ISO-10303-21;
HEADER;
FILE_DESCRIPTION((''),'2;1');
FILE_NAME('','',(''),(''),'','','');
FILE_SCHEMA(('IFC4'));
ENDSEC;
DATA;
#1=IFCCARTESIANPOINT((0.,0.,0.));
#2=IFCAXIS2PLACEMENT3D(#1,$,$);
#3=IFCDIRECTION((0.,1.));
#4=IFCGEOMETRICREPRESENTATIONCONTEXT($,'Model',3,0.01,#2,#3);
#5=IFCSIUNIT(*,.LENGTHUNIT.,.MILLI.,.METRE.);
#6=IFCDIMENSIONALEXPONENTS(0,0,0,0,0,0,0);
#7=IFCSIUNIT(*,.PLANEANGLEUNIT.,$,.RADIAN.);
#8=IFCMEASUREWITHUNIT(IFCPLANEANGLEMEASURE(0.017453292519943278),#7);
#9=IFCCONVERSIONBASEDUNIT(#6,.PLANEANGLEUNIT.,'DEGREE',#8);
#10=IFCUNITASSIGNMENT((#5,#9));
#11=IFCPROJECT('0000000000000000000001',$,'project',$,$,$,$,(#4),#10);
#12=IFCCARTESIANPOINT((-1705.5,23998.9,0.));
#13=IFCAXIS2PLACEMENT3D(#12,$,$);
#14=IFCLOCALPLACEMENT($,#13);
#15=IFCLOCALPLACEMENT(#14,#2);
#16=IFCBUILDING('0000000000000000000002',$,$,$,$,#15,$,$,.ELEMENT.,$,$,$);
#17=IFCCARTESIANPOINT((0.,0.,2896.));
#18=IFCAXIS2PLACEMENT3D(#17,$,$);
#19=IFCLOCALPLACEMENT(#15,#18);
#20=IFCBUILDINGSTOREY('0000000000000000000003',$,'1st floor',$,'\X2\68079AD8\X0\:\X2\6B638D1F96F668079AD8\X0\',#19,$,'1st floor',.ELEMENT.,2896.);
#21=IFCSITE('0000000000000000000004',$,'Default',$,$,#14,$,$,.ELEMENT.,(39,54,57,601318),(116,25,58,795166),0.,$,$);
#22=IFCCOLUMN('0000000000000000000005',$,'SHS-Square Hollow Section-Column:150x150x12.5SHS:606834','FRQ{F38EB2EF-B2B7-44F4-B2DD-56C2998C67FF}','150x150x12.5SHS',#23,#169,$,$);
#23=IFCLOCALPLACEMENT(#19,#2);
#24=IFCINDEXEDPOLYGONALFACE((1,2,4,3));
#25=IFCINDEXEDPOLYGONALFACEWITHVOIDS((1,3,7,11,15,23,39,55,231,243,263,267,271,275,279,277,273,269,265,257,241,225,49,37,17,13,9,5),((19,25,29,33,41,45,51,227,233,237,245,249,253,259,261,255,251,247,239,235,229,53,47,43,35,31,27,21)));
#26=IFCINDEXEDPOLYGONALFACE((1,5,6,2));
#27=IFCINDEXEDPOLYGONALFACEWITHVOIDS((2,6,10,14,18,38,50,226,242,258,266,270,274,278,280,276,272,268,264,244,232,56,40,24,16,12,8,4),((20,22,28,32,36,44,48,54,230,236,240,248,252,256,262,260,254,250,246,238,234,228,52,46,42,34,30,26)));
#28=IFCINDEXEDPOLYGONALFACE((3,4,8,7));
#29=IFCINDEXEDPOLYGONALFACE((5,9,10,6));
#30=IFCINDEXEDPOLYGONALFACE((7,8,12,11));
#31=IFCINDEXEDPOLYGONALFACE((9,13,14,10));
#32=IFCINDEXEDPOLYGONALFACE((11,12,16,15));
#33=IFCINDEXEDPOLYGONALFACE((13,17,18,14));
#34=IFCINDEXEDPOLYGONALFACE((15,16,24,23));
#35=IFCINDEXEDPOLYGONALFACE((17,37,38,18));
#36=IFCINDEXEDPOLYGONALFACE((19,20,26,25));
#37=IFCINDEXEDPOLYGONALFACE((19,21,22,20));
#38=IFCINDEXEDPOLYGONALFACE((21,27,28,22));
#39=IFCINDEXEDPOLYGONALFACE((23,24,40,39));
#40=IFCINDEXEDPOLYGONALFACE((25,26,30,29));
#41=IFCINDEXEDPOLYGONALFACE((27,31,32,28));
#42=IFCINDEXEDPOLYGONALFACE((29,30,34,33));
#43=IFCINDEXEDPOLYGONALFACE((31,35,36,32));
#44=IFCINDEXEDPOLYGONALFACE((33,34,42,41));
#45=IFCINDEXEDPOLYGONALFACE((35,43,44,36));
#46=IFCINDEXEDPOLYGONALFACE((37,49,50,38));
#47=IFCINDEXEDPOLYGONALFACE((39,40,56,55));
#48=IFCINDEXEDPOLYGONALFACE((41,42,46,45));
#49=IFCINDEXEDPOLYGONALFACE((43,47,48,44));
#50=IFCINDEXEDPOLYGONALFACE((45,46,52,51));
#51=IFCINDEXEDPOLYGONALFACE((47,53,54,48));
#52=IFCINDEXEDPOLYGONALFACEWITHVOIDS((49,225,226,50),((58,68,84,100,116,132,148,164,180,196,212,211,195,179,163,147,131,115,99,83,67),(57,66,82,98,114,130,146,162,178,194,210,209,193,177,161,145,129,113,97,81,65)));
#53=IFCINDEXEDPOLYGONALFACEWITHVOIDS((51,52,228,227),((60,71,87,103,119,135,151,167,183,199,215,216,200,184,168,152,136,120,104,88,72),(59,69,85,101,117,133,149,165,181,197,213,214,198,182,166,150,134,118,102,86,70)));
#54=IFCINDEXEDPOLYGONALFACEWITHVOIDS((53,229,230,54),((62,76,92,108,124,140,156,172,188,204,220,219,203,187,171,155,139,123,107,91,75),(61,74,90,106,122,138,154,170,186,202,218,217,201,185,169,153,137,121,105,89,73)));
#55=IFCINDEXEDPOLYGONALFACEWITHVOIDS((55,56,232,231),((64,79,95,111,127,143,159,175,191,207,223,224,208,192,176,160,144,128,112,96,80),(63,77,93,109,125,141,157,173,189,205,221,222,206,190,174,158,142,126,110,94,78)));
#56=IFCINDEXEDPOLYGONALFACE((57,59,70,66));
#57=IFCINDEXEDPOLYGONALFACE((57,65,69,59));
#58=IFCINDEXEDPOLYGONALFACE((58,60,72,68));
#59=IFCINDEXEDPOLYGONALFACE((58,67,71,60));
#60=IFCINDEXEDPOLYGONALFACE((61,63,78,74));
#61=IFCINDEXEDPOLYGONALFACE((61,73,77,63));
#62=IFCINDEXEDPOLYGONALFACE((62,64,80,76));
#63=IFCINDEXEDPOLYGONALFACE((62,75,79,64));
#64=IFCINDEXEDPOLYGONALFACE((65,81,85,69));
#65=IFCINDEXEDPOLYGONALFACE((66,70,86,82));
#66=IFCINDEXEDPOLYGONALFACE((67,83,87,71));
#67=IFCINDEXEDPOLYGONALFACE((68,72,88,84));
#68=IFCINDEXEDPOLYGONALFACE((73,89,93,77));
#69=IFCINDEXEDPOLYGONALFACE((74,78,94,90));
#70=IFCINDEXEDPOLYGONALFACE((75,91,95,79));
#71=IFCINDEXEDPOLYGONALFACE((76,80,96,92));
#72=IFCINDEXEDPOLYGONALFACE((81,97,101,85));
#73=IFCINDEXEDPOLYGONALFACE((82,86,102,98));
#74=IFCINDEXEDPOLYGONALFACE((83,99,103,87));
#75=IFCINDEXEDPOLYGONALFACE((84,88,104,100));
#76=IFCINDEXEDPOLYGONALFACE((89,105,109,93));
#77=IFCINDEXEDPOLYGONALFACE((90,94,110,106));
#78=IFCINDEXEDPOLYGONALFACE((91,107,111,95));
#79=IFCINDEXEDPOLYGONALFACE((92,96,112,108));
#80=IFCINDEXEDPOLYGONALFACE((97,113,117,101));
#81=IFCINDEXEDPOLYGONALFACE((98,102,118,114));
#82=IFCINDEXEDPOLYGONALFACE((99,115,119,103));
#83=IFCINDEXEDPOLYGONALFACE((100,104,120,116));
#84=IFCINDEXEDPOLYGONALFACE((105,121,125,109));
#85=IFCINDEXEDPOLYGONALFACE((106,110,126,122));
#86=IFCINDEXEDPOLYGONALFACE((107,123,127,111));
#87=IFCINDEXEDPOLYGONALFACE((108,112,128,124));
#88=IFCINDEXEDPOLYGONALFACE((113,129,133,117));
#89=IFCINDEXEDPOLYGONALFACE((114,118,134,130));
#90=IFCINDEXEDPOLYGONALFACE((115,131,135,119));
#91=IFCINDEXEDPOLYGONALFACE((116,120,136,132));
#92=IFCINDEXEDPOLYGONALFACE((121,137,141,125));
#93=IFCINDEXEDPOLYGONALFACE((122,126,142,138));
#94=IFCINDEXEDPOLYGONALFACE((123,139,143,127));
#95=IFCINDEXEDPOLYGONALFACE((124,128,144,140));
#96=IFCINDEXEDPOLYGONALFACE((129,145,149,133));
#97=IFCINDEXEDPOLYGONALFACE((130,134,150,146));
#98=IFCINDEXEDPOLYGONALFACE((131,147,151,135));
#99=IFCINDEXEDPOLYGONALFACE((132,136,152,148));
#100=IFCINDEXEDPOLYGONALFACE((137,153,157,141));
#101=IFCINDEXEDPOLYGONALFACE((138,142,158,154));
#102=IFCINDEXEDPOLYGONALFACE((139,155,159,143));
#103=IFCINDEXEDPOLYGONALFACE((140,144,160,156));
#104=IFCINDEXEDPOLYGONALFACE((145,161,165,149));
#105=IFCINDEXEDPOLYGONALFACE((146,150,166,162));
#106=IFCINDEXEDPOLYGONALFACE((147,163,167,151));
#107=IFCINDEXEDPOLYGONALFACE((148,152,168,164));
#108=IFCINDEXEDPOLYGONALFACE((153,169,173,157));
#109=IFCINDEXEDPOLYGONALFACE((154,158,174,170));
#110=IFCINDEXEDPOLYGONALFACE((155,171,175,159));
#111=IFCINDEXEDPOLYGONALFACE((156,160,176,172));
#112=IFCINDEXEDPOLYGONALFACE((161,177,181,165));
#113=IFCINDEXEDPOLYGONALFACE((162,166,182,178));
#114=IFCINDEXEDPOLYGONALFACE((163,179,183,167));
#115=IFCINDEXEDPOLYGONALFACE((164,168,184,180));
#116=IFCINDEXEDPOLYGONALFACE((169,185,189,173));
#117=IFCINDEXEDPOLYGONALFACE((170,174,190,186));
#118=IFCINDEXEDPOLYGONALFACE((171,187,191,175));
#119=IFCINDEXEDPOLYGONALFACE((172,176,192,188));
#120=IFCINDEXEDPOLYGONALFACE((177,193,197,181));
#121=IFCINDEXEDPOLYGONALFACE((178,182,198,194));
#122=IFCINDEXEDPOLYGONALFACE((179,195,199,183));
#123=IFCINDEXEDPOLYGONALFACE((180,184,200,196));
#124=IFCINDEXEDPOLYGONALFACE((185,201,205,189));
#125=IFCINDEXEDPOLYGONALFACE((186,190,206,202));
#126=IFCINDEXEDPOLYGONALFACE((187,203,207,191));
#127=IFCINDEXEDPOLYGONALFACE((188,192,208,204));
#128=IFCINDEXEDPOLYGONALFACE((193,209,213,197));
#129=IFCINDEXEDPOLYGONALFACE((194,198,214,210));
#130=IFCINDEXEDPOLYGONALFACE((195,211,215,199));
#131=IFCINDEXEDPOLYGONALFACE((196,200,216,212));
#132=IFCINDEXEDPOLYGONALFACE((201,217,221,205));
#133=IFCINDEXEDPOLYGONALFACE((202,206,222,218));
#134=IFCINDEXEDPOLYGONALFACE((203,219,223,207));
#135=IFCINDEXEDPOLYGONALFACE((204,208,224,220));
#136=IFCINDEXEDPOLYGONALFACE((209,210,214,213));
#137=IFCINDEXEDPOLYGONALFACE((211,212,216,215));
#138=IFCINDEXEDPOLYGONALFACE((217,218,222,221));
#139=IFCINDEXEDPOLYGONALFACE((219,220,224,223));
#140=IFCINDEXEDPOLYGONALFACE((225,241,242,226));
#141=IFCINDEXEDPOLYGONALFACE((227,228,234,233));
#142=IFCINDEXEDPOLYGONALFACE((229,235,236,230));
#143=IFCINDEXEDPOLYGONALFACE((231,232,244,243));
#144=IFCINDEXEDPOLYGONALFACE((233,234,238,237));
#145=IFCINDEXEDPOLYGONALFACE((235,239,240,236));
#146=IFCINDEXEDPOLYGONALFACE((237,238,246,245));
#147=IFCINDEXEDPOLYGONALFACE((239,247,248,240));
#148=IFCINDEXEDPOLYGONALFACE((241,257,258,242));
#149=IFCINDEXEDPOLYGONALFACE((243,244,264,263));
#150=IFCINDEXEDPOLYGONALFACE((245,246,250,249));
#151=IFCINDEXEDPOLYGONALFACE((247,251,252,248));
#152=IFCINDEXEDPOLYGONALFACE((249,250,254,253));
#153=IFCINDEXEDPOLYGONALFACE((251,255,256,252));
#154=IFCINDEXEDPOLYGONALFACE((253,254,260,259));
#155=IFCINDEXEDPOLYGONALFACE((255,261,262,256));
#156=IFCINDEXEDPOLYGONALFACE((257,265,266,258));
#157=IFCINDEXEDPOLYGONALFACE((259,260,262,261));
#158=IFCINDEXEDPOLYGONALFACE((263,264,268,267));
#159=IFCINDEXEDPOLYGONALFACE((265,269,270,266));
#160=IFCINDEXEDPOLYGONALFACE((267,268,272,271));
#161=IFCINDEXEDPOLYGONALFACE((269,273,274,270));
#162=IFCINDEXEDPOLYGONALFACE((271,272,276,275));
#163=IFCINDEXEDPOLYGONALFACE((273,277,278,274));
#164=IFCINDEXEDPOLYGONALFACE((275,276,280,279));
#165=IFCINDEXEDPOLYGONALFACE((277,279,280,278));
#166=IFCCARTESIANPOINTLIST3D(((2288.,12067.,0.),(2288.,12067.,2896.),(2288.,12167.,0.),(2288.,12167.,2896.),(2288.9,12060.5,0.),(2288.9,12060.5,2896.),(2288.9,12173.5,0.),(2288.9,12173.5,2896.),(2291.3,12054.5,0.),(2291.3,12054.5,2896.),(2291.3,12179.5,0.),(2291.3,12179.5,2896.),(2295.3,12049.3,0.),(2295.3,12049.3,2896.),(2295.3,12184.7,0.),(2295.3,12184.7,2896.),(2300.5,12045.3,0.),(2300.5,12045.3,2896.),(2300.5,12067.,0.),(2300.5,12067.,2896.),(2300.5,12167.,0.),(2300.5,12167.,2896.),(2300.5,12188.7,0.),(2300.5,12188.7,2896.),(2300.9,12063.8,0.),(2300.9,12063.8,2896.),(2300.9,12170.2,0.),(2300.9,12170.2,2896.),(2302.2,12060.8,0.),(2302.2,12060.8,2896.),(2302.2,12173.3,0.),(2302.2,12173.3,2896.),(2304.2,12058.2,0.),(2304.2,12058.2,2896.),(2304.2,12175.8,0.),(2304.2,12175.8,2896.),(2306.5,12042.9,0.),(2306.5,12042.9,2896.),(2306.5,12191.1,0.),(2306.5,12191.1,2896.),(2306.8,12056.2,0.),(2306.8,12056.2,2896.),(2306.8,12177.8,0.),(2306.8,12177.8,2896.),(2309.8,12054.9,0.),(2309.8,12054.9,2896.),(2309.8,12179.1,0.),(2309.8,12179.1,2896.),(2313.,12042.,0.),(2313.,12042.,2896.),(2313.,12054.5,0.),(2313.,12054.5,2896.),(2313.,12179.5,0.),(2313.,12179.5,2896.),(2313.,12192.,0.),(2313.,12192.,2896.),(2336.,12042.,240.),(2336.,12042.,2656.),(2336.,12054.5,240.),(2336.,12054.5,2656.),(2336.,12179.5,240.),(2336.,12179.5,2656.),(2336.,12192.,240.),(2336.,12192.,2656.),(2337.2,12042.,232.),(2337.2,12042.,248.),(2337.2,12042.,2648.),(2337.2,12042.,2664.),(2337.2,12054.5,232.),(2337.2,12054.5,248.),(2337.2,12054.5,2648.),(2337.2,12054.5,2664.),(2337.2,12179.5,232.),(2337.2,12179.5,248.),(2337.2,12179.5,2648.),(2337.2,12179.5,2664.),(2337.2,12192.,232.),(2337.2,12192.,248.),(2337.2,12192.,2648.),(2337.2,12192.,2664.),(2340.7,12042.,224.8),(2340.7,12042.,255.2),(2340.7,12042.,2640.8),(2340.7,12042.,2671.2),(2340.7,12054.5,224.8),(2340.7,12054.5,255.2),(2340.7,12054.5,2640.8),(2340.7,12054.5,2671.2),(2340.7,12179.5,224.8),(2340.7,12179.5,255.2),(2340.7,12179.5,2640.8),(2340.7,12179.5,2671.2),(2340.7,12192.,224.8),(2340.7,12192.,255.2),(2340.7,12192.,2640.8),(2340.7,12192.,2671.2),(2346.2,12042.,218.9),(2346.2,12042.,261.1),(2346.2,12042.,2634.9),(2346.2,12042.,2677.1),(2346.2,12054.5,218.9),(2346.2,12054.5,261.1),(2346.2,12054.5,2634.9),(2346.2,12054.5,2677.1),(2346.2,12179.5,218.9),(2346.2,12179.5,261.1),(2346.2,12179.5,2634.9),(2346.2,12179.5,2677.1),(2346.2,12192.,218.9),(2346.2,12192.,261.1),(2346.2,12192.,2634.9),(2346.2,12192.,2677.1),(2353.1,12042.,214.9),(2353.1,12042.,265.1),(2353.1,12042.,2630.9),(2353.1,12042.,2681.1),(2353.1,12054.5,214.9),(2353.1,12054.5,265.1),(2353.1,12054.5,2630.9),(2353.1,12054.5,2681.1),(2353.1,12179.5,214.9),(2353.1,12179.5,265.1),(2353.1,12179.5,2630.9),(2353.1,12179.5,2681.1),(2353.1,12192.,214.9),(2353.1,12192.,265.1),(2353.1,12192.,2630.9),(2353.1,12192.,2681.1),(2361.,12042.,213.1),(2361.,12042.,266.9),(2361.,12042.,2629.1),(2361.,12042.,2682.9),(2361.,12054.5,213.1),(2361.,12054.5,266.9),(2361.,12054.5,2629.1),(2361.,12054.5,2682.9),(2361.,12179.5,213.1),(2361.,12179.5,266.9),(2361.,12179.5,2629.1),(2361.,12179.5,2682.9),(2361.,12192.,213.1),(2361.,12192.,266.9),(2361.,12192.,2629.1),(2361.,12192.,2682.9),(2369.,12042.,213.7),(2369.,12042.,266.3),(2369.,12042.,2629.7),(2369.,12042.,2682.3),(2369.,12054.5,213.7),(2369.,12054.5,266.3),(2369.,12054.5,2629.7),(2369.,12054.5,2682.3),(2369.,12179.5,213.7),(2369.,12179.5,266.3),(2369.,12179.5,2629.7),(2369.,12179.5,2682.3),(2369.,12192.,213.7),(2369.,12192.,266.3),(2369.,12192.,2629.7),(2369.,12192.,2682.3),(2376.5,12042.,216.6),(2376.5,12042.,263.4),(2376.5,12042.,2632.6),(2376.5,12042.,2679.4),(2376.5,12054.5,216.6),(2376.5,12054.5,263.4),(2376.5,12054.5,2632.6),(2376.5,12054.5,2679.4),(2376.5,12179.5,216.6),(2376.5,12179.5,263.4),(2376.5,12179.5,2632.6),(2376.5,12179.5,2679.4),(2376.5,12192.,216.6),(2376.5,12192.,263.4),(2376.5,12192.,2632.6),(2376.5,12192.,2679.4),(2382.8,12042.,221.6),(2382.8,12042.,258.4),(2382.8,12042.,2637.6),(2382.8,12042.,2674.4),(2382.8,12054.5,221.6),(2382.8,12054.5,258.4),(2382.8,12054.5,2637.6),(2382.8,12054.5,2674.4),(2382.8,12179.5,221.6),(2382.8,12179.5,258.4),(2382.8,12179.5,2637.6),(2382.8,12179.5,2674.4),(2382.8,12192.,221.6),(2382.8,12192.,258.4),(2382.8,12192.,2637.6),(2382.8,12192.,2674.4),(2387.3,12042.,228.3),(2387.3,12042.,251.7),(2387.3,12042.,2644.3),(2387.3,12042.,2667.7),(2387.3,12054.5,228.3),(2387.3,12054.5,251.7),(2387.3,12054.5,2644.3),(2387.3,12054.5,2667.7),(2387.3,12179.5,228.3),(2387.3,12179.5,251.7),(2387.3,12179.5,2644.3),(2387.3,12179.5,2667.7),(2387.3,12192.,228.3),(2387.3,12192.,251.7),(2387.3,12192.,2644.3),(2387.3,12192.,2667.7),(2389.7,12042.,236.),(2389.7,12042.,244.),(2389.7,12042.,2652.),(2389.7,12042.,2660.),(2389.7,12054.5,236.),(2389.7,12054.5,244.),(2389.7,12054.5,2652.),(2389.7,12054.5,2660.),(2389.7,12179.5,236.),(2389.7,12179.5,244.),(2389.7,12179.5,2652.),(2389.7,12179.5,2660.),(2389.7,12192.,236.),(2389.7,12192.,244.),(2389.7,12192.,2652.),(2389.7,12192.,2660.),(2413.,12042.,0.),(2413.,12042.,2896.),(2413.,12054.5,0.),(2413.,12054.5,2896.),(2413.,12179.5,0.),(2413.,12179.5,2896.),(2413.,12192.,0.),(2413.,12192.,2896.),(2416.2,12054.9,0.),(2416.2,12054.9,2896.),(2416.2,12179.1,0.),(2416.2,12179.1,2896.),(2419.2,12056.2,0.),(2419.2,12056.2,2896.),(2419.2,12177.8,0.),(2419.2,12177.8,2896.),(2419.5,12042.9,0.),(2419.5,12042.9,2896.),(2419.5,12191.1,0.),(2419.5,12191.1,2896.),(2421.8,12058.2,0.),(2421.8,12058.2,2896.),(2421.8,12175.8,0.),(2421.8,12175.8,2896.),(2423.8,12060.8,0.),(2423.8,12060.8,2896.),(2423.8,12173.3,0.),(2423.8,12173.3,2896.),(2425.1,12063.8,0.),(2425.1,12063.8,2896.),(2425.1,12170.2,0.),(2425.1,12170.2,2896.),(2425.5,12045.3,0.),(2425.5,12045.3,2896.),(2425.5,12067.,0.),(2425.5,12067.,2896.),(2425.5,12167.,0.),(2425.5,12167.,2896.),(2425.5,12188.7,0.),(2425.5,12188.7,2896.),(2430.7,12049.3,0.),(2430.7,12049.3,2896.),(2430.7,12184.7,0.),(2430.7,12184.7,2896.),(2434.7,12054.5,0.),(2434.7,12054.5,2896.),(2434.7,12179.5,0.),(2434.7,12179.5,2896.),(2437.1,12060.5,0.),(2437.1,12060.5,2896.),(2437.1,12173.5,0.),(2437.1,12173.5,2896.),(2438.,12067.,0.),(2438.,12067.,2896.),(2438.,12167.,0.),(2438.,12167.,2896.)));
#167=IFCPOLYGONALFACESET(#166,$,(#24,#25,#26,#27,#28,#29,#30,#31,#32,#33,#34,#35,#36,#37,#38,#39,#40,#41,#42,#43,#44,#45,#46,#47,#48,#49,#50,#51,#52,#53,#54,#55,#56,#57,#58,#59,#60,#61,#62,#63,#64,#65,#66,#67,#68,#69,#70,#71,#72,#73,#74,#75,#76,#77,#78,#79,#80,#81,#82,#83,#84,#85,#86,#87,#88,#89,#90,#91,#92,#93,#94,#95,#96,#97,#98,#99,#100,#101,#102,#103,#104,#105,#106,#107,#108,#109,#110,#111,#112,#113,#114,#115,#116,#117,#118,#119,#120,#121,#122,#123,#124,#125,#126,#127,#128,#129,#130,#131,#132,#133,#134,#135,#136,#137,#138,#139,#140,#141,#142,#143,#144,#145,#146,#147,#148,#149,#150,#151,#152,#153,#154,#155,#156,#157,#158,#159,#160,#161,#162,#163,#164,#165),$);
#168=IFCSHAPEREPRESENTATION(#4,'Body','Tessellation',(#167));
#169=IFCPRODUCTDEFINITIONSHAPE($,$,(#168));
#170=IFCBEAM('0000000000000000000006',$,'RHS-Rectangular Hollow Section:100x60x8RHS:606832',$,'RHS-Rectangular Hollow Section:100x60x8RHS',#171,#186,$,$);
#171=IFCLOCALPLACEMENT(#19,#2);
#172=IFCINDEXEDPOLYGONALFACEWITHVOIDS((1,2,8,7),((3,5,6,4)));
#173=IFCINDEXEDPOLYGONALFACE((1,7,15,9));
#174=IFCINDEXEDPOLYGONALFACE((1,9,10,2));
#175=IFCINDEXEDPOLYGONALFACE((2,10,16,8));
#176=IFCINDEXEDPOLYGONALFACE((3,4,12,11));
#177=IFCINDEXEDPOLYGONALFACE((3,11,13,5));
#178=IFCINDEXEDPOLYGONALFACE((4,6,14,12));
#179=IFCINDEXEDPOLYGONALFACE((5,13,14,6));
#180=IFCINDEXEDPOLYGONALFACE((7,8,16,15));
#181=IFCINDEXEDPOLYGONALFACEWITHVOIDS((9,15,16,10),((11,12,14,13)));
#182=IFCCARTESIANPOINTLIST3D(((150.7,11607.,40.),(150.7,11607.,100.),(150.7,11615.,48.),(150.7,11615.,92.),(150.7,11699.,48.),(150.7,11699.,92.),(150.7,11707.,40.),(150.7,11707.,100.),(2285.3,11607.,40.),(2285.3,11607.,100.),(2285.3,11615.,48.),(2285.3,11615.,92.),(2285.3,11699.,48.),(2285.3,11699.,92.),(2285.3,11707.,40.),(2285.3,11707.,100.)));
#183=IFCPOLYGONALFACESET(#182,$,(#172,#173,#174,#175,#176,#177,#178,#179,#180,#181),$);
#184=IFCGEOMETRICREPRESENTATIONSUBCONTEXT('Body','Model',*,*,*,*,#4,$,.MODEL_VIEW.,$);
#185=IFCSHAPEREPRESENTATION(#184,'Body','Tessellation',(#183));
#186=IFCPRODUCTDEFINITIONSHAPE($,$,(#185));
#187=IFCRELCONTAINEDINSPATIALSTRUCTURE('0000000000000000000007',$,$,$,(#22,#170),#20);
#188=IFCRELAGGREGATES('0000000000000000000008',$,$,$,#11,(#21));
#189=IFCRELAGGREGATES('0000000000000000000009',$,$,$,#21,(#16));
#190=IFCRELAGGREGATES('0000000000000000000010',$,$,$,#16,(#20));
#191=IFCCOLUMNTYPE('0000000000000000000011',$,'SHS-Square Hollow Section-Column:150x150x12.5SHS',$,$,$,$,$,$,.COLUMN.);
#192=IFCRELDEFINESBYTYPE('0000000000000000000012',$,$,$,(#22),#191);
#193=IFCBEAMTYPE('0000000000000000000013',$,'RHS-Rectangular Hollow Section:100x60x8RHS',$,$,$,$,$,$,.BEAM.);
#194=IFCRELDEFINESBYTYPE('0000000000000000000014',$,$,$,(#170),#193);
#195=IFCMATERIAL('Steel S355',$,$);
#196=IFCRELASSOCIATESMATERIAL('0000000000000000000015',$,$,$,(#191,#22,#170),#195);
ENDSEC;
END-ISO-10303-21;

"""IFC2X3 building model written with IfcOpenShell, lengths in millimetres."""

from ifc_helpers import new_model, entity, si_unit, converted_unit, direction, frame, frame_2d, origin, origin_2d, place, context, subcontext, project, spatial, circle_curve, rectangle, hollow_rectangle, outline, extrude, boolean, material, type_object, element, save


model = new_model("IFC2X3")

# Units and contexts
model_context = context("Model", 3, precision=0.01, world=origin(), true_north=direction((0.0, 1.0)))
body_context = subcontext(model_context, "Body", "Model", "MODEL_VIEW")
ifc_project = project(units=[si_unit("LENGTHUNIT", "METRE", prefix="MILLI"), converted_unit("PLANEANGLEUNIT", "DEGREE", entity("IfcPlaneAngleMeasure", 0.017453292519943278), si_unit("PLANEANGLEUNIT", "RADIAN"), dimensions=[0, 0, 0, 0, 0, 0, 0])], contexts=[model_context])

# Site, building, storey
site_placement = place(None, frame((-1705.5, 23998.9, 0.0)))
site = spatial("IfcSite", under=ifc_project, at=site_placement, Name="Default", CompositionType="ELEMENT", RefLatitude=(39, 54, 57, 601318), RefLongitude=(116, 25, 58, 795166), RefElevation=0.0)
building_placement = place(site_placement, origin())
building = spatial("IfcBuilding", under=site, at=building_placement, CompositionType="ELEMENT")
storey_placement = place(building_placement, frame((0.0, 0.0, 2896.0)))
storey = spatial("IfcBuildingStorey", under=building, at=storey_placement, Name="1st floor", ObjectType="标高:正负零标高", LongName="1st floor", CompositionType="ELEMENT", Elevation=2896.0)

# Shared definitions
ifc_material_1 = material(Name="Steel S355")

# Column, openings
column_type_1 = type_object("IfcColumnType", Name="SHS-Square Hollow Section-Column:150x150x12.5SHS", PredefinedType="COLUMN", material=ifc_material_1)
column_1_placement = place(storey_placement, frame((2363.0, 12117.0, 2896.0), z_axis=(0.0, 0.0, 1.0), x_axis=(0.0, -1.0, 0.0)))
column_1 = element("IfcColumn", 1, at=column_1_placement, inside=storey, type_object=column_type_1, material=ifc_material_1, Name="SHS-Square Hollow Section-Column:150x150x12.5SHS:606834", Description="FRQ{F38EB2EF-B2B7-44F4-B2DD-56C2998C67FF}", ObjectType="150x150x12.5SHS", context=model_context, shape_type="SweptSolid", body=[
    extrude(hollow_rectangle(XDim=150.0, YDim=150.0, WallThickness=12.5, InnerFilletRadius=12.5, OuterFilletRadius=25.0, at=origin_2d()), origin(), (0.0, 0.0, -1.0), 2896.0),
])
opening_1_placement = place(column_1_placement, frame((175.1, 0.0, 0.0), z_axis=(-1.0, 0.0, 0.0), x_axis=(0.0, -1.0, 0.0)))
element("IfcOpeningElement", 2, at=opening_1_placement, cuts=column_1, ObjectType="Opening", context=model_context, shape_type="SweptSolid", body=[
    extrude(outline(circle_curve(frame_2d((0.0, -240.0), x_axis=(1.0, 0.0)), 27.0)), origin(), (0.0, 0.0, 1.0), 350.2),
])
opening_2_placement = place(column_1_placement, frame((175.1, 0.0, -2896.0), z_axis=(-1.0, 0.0, 0.0), x_axis=(0.0, -1.0, 0.0)))
element("IfcOpeningElement", 3, at=opening_2_placement, cuts=column_1, ObjectType="Opening", context=model_context, shape_type="SweptSolid", body=[
    extrude(outline(circle_curve(frame_2d((0.0, 240.0), x_axis=(1.0, 0.0)), 27.0)), origin(), (0.0, 0.0, 1.0), 350.2),
])

# Beam
beam_type_1 = type_object("IfcBeamType", Name="RHS-Rectangular Hollow Section:100x60x8RHS", PredefinedType="BEAM")
beam_1_placement = place(storey_placement, frame((150.7, 11707.0, 70.0)))
element("IfcBeam", 4, at=beam_1_placement, inside=storey, type_object=beam_type_1, material=ifc_material_1, Name="RHS-Rectangular Hollow Section:100x60x8RHS:606832", ObjectType="RHS-Rectangular Hollow Section:100x60x8RHS", context=body_context, shape_type="SweptSolid", body=[
    boolean("DIFFERENCE", extrude(rectangle(XDim=60.0, YDim=100.0, at=frame_2d((0.0, 0.0), x_axis=(1.0, 0.0))), frame((0.0, -50.0, 0.0), z_axis=(1.0, 0.0, 0.0), x_axis=(0.0, 0.0, -1.0)), (0.0, 0.0, 1.0), 2134.6), extrude(rectangle(XDim=44.0, YDim=84.0, at=frame_2d((0.0, 0.0), x_axis=(0.0, 1.0))), frame((2134.6, -50.0, 0.0), z_axis=(-1.0, 0.0, 0.0), x_axis=(0.0, 1.0, 0.0)), (0.0, 0.0, 1.0), 2134.6)),
])

save(model, "model.ifc")
